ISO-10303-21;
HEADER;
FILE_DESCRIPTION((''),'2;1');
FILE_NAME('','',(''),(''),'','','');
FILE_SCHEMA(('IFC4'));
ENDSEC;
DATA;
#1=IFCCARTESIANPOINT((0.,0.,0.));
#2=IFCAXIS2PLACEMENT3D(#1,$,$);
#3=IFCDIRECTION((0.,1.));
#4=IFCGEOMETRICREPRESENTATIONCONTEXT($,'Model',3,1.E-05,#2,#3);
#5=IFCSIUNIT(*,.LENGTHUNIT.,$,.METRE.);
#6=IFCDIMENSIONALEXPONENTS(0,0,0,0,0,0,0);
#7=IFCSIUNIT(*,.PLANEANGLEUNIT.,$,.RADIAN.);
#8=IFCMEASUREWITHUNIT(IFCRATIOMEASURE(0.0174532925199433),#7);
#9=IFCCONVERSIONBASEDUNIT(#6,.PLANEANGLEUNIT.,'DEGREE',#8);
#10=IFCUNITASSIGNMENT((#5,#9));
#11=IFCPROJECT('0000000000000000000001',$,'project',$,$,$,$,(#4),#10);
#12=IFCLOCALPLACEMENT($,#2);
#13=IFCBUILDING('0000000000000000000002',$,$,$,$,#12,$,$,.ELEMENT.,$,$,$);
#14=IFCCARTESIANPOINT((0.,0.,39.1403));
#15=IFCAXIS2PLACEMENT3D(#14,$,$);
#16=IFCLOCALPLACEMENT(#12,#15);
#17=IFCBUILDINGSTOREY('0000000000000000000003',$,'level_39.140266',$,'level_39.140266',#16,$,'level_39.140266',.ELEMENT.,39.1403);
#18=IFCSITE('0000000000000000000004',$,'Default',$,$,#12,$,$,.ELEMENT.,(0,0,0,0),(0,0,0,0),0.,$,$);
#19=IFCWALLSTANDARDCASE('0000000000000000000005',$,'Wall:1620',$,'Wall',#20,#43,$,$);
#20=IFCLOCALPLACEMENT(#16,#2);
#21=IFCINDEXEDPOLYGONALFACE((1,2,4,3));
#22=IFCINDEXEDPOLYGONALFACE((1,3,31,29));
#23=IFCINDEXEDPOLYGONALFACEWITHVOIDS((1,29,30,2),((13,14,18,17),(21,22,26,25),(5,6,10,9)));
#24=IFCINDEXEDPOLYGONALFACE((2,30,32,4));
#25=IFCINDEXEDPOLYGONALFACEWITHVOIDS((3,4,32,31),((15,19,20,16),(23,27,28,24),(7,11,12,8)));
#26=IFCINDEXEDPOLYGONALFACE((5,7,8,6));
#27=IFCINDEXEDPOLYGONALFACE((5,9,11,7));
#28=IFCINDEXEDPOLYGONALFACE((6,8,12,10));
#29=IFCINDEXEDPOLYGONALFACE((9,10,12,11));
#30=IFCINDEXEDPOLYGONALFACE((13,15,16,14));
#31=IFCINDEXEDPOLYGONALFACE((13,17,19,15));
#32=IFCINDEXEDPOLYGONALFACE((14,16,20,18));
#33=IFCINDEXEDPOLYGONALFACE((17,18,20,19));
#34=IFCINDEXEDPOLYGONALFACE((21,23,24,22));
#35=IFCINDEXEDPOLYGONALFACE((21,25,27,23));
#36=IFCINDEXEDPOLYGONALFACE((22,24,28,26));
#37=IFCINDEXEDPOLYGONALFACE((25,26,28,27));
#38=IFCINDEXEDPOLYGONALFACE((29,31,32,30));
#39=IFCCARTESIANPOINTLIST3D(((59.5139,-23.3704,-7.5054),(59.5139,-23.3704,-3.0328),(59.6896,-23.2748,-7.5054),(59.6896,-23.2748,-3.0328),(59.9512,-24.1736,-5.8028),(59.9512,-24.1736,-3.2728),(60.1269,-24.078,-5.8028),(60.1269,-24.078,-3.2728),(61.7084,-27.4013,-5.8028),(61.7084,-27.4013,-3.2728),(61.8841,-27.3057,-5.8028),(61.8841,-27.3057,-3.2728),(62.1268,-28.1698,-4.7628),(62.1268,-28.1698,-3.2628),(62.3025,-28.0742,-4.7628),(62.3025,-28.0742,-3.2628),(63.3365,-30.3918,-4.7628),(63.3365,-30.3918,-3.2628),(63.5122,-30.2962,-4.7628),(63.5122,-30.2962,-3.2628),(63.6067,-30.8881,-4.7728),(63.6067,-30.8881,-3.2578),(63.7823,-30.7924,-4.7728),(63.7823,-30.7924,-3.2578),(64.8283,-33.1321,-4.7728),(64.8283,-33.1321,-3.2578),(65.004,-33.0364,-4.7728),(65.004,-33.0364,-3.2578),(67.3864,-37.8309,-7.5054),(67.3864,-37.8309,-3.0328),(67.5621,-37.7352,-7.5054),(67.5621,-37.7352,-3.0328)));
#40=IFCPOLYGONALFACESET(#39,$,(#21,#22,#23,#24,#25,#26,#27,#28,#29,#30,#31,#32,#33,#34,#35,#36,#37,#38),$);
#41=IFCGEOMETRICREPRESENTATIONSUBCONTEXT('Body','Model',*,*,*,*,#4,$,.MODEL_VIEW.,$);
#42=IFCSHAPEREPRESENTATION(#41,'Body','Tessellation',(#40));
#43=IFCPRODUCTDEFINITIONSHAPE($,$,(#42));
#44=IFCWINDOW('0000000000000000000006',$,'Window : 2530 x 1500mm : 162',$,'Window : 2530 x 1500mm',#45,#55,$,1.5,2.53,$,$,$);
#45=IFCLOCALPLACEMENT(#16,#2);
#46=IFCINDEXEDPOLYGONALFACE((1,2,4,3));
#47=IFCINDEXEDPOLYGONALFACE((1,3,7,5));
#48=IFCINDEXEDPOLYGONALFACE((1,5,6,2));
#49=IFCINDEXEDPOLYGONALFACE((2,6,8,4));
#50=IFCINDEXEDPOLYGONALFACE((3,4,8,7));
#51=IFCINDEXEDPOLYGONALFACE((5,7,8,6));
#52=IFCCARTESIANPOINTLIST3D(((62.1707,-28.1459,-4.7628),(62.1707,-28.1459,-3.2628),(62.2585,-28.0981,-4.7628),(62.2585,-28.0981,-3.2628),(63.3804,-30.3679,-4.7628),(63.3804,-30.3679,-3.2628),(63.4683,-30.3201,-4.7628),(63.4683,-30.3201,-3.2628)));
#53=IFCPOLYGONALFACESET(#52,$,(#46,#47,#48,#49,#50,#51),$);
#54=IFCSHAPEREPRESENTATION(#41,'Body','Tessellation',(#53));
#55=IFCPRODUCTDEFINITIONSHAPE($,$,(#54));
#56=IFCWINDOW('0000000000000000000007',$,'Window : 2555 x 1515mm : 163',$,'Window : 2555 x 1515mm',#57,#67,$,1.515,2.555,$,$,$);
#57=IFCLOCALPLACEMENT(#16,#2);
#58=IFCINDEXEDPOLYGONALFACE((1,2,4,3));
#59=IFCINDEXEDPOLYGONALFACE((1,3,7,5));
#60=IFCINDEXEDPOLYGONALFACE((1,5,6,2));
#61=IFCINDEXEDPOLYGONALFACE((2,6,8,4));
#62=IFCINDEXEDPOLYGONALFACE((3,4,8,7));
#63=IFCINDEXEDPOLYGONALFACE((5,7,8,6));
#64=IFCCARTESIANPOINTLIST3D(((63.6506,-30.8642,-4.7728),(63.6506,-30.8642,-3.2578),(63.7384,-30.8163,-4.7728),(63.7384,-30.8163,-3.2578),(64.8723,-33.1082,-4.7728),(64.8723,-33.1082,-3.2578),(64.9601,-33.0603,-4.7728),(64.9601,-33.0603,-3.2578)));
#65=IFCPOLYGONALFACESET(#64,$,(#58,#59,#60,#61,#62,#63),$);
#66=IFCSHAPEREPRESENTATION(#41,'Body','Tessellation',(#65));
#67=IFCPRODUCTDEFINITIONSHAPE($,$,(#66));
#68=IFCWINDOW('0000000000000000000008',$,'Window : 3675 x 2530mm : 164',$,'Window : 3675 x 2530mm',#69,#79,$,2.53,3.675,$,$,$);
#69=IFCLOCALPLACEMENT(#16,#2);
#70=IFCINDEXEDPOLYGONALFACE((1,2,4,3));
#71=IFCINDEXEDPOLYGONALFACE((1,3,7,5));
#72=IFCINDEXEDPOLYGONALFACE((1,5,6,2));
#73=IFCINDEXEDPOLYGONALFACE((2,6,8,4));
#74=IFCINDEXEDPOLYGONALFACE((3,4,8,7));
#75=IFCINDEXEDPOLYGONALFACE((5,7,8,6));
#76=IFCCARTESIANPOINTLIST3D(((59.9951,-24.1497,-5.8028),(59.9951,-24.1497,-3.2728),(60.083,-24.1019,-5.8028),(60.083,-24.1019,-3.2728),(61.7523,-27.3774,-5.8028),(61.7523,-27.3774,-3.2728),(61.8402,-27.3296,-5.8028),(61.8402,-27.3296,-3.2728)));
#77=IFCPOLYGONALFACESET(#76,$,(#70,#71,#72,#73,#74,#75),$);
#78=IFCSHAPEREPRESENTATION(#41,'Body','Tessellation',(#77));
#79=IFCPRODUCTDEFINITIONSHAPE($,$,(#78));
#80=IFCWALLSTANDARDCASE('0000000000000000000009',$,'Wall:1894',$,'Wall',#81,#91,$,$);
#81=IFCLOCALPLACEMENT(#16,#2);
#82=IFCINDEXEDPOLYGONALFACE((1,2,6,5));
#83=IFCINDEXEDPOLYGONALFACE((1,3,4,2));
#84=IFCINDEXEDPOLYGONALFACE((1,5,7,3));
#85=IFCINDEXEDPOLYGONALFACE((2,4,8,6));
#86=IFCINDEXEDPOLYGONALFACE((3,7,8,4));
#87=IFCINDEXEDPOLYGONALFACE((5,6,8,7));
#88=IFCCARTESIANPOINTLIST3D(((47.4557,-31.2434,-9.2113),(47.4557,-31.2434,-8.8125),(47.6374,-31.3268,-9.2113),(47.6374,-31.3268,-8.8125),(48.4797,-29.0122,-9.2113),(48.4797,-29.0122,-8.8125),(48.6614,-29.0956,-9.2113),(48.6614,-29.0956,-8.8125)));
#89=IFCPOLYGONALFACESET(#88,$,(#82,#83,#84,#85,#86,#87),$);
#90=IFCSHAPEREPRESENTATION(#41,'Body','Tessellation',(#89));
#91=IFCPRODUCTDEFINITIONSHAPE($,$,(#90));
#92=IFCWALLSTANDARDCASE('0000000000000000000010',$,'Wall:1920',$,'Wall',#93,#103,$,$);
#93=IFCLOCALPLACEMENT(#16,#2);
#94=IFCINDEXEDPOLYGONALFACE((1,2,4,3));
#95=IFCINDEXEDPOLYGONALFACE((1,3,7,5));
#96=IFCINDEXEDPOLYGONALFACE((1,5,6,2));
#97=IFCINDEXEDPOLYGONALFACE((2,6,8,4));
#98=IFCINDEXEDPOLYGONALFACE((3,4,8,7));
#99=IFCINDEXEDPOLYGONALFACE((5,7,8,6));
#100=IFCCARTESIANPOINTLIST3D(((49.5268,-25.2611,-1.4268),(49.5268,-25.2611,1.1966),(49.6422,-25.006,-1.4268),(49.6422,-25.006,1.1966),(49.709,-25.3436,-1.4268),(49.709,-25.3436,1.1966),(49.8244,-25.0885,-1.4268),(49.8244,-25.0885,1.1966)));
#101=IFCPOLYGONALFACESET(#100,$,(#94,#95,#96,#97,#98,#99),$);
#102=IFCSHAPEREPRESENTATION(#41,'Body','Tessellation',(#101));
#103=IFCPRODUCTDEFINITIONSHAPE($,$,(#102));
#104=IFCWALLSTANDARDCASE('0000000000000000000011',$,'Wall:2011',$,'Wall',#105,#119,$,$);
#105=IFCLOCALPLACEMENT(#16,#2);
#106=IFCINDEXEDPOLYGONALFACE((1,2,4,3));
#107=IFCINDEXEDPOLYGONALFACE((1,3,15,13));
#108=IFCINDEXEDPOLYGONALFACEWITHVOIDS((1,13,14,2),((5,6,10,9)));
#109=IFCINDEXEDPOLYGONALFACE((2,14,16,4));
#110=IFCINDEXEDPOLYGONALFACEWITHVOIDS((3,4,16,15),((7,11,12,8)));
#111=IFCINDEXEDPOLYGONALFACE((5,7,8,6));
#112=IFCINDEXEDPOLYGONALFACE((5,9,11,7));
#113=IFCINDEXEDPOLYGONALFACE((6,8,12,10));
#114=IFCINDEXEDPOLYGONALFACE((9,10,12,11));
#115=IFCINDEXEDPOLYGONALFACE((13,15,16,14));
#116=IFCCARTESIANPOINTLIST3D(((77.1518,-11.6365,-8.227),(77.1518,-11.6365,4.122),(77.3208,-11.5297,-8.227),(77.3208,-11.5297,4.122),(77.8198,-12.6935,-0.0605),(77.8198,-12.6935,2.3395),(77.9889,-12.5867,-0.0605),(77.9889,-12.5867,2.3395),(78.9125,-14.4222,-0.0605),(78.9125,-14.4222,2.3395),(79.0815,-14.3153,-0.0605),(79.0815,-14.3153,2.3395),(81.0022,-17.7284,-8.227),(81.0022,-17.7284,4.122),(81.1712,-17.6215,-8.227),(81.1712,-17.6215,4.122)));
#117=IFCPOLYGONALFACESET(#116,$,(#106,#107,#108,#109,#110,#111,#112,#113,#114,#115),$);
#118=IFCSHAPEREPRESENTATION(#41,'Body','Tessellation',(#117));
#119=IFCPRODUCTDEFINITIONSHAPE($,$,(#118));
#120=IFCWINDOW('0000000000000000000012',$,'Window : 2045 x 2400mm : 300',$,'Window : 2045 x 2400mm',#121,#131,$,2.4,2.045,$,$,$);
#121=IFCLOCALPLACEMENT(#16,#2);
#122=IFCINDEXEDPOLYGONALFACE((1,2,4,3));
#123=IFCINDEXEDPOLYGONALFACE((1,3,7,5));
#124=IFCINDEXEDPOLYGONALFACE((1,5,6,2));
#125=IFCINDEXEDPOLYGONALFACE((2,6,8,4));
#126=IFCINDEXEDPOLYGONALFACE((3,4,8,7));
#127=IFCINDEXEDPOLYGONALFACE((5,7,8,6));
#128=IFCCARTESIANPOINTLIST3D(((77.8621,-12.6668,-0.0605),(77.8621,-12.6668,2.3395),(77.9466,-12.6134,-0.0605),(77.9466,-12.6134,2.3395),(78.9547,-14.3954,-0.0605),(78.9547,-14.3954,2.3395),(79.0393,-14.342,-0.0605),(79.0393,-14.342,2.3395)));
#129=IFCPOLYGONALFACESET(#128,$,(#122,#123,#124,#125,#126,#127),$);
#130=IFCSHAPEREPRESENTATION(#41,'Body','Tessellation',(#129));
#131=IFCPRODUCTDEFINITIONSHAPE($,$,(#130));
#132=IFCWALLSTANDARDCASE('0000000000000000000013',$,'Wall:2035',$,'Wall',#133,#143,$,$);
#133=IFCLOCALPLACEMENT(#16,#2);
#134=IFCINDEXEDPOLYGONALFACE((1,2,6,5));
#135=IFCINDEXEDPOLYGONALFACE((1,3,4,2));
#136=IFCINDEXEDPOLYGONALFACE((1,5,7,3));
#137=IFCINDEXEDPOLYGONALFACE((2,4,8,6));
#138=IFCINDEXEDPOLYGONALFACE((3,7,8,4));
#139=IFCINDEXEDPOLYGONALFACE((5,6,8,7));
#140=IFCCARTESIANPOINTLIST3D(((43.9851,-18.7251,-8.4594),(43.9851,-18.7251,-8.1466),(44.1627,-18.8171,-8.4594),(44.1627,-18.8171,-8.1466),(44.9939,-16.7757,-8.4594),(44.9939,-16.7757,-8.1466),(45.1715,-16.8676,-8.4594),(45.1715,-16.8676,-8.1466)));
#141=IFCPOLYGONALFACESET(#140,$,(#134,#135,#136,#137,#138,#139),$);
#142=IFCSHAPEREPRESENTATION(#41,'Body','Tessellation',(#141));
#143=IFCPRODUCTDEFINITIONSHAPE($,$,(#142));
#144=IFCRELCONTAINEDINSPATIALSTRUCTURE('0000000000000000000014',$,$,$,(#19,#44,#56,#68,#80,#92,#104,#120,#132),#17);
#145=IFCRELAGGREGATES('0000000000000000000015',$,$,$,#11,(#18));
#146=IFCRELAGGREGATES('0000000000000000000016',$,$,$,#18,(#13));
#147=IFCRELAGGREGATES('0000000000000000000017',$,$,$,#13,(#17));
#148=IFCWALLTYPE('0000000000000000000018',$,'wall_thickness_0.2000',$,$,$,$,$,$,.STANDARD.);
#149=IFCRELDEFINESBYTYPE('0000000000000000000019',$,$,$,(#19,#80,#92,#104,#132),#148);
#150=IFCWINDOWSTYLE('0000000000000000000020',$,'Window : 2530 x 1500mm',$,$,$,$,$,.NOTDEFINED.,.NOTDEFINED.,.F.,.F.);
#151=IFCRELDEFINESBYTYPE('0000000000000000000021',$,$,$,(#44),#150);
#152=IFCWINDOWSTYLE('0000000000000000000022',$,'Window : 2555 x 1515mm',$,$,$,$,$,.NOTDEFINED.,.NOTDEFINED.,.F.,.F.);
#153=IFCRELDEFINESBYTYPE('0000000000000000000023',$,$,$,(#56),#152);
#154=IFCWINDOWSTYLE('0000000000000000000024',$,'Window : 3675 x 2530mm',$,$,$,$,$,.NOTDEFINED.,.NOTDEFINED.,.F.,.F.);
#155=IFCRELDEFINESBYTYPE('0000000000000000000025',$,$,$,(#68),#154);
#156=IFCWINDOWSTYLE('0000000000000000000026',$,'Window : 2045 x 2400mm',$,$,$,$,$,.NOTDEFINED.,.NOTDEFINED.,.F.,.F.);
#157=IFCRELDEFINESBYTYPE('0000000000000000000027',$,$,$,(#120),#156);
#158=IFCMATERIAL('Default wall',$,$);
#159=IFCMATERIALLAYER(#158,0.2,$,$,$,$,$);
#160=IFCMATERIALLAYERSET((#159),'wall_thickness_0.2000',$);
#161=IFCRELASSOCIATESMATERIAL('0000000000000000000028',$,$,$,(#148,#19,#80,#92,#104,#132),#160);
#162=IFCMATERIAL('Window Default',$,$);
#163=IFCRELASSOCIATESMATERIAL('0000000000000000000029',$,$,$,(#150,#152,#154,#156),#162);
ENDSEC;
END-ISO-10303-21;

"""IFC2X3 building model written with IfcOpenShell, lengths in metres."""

from ifc_helpers import new_model, entity, si_unit, converted_unit, direction, frame, frame_2d, origin, origin_2d_with_axis, place, context, subcontext, project, spatial, polyline, rectangle, outline, extrude, source, transform, mapped, material, layer, layer_set, layer_usage, type_object, type_shapes, element, fill, save


model = new_model("IFC2X3")

# Units and contexts
model_context = context("Model", 3, precision=1e-05, world=origin(), true_north=direction((0.0, 1.0)))
body_context = subcontext(model_context, "Body", "Model", "MODEL_VIEW")
ifc_project = project(units=[si_unit("LENGTHUNIT", "METRE"), converted_unit("PLANEANGLEUNIT", "DEGREE", entity("IfcRatioMeasure", 0.0174532925199433), si_unit("PLANEANGLEUNIT", "RADIAN"), dimensions=[0, 0, 0, 0, 0, 0, 0])], contexts=[model_context])

# Site, building, storey
placement_1 = place(None, origin())
site = spatial("IfcSite", under=ifc_project, at=placement_1, Name="Default", CompositionType="ELEMENT", RefLatitude=(0, 0, 0, 0), RefLongitude=(0, 0, 0, 0), RefElevation=0.0)
building = spatial("IfcBuilding", under=site, at=placement_1, CompositionType="ELEMENT")
storey_placement = place(placement_1, frame((0.0, 0.0, 39.1403)))
storey = spatial("IfcBuildingStorey", under=building, at=storey_placement, Name="level_39.140266", ObjectType="level_39.140266", LongName="level_39.140266", CompositionType="ELEMENT", Elevation=39.1403)

# Shared definitions
ifc_material_1 = material(Name="Default wall")
ifc_layer = layer(ifc_material_1, 0.2)
ifc_layer_set = layer_set([ifc_layer], Name="wall_thickness_0.2000")
ifc_layer_usage = layer_usage(ifc_layer_set, "AXIS2", "POSITIVE", -0.1)
wall_type = type_object("IfcWallType", Name="wall_thickness_0.2000", PredefinedType="STANDARD", material=ifc_layer_set)

# Shared definitions
ifc_material_2 = material(Name="Window Default")

# Wall, openings, windows
placement_2 = place(placement_1, frame((0.0, 0.0, 31.6349)))
wall_1_placement = place(placement_2, frame((59.6018, -23.3226, 0.0), z_axis=(0.0, 0.0, 1.0), x_axis=(0.478148, -0.878279, 0.0)))
wall_1 = element("IfcWallStandardCase", 1, at=wall_1_placement, inside=storey, type_object=wall_type, material=ifc_layer_usage, Name="Wall:1620", ObjectType="Wall", context=body_context, shape_type="SweptSolid", body=[
    extrude(outline(polyline([(16.4645, -0.1), (16.4645, 0.1), (0.0, 0.1), (0.0, -0.1), (16.4645, -0.1)])), origin(), (0.0, 0.0, 1.0), 4.4726),
])
opening_1_placement = place(wall_1_placement, frame((5.4645, -0.1, 2.7426)))
opening_1 = element("IfcOpeningElement", 2, at=opening_1_placement, cuts=wall_1, ObjectType="Opening", context=body_context, shape_type="SweptSolid", body=[
    extrude(rectangle(XDim=2.53, YDim=1.5, at=frame_2d((0.75, 1.265), x_axis=(0.0, 1.0))), frame((0.0, 0.0, 0.0), z_axis=(0.0, 1.0, 0.0), x_axis=(0.0, 0.0, 1.0)), (0.0, 0.0, 1.0), 0.2),
])
opening_2_placement = place(wall_1_placement, frame((8.5595, -0.1, 2.7326)))
opening_2 = element("IfcOpeningElement", 3, at=opening_2_placement, cuts=wall_1, ObjectType="Opening", context=body_context, shape_type="SweptSolid", body=[
    extrude(rectangle(XDim=2.555, YDim=1.515, at=frame_2d((0.7575, 1.2775), x_axis=(0.0, 1.0))), frame((0.0, 0.0, 0.0), z_axis=(0.0, 1.0, 0.0), x_axis=(0.0, 0.0, 1.0)), (0.0, 0.0, 1.0), 0.2),
])
opening_3_placement = place(wall_1_placement, frame((0.9145, -0.1, 1.7026)))
opening_3 = element("IfcOpeningElement", 4, at=opening_3_placement, cuts=wall_1, ObjectType="Opening", context=body_context, shape_type="SweptSolid", body=[
    extrude(rectangle(XDim=3.675, YDim=2.53, at=frame_2d((1.265, 1.8375), x_axis=(0.0, 1.0))), frame((0.0, 0.0, 0.0), z_axis=(0.0, 1.0, 0.0), x_axis=(0.0, 0.0, 1.0)), (0.0, 0.0, 1.0), 0.2),
])
window_style_1 = type_object("IfcWindowStyle", Name="Window : 2530 x 1500mm", ConstructionType="NOTDEFINED", OperationType="NOTDEFINED", ParameterTakesPrecedence=False, Sizeable=False, material=ifc_material_2)
shared_shape_1 = source(origin(), body_context, "Body", "SweptSolid", [
    extrude(rectangle(XDim=0.1, YDim=2.53, at=origin_2d_with_axis()), frame((1.265, 0.1, 0.0), z_axis=(0.0, 0.0, 1.0), x_axis=(0.0, 1.0, 0.0)), (0.0, 0.0, 1.0), 1.5),
])
type_shapes(window_style_1, [shared_shape_1])
window_1_placement = place(opening_1_placement, origin())
window_1 = element("IfcWindow", 5, at=window_1_placement, inside=storey, type_object=window_style_1, Name="Window : 2530 x 1500mm : 162", ObjectType="Window : 2530 x 1500mm", OverallHeight=1.5, OverallWidth=2.53, context=body_context, shape_type="MappedRepresentation", body=[
    mapped(shared_shape_1, transform((0.0, 0.0, 0.0), scale=1.0)),
])
fill(opening_1, window_1)
window_style_2 = type_object("IfcWindowStyle", Name="Window : 2555 x 1515mm", ConstructionType="NOTDEFINED", OperationType="NOTDEFINED", ParameterTakesPrecedence=False, Sizeable=False, material=ifc_material_2)
shared_shape_2 = source(origin(), body_context, "Body", "SweptSolid", [
    extrude(rectangle(XDim=0.1, YDim=2.555, at=origin_2d_with_axis()), frame((1.2775, 0.1, 0.0), z_axis=(0.0, 0.0, 1.0), x_axis=(0.0, 1.0, 0.0)), (0.0, 0.0, 1.0), 1.515),
])
type_shapes(window_style_2, [shared_shape_2])
window_2_placement = place(opening_2_placement, origin())
window_2 = element("IfcWindow", 6, at=window_2_placement, inside=storey, type_object=window_style_2, Name="Window : 2555 x 1515mm : 163", ObjectType="Window : 2555 x 1515mm", OverallHeight=1.515, OverallWidth=2.555, context=body_context, shape_type="MappedRepresentation", body=[
    mapped(shared_shape_2, transform((0.0, 0.0, 0.0), scale=1.0)),
])
fill(opening_2, window_2)
window_style_3 = type_object("IfcWindowStyle", Name="Window : 3675 x 2530mm", ConstructionType="NOTDEFINED", OperationType="NOTDEFINED", ParameterTakesPrecedence=False, Sizeable=False, material=ifc_material_2)
shared_shape_3 = source(origin(), body_context, "Body", "SweptSolid", [
    extrude(rectangle(XDim=0.1, YDim=3.675, at=origin_2d_with_axis()), frame((1.8375, 0.1, 0.0), z_axis=(0.0, 0.0, 1.0), x_axis=(0.0, 1.0, 0.0)), (0.0, 0.0, 1.0), 2.53),
])
type_shapes(window_style_3, [shared_shape_3])
window_3_placement = place(opening_3_placement, origin())
window_3 = element("IfcWindow", 7, at=window_3_placement, inside=storey, type_object=window_style_3, Name="Window : 3675 x 2530mm : 164", ObjectType="Window : 3675 x 2530mm", OverallHeight=2.53, OverallWidth=3.675, context=body_context, shape_type="MappedRepresentation", body=[
    mapped(shared_shape_3, transform((0.0, 0.0, 0.0), scale=1.0)),
])
fill(opening_3, window_3)

# Walls
placement_3 = place(placement_1, frame((0.0, 0.0, 29.929)))
wall_2_placement = place(placement_3, frame((47.5465, -31.2851, 0.0), z_axis=(0.0, 0.0, 1.0), x_axis=(0.41711, 0.908856, 0.0)))
element("IfcWallStandardCase", 8, at=wall_2_placement, inside=storey, type_object=wall_type, material=ifc_layer_usage, Name="Wall:1894", ObjectType="Wall", context=body_context, shape_type="SweptSolid", body=[
    extrude(outline(polyline([(2.455, -0.1), (2.455, 0.1), (0.0, 0.1), (0.0, -0.1), (2.455, -0.1)])), origin(), (0.0, 0.0, 1.0), 0.3988),
])
placement_4 = place(placement_1, frame((0.0, 0.0, 37.7135)))
wall_3_placement = place(placement_4, frame((49.6179, -25.3024, 0.0), z_axis=(0.0, 0.0, 1.0), x_axis=(0.412343, 0.911029, 0.0)))
element("IfcWallStandardCase", 9, at=wall_3_placement, inside=storey, type_object=wall_type, material=ifc_layer_usage, Name="Wall:1920", ObjectType="Wall", context=body_context, shape_type="SweptSolid", body=[
    extrude(outline(polyline([(0.28, -0.1), (0.28, 0.1), (0.0, 0.1), (0.0, -0.1), (0.28, -0.1)])), origin(), (0.0, 0.0, 1.0), 2.6234),
])

# Wall, opening, window
placement_5 = place(placement_1, frame((0.0, 0.0, 30.9133)))
wall_4_placement = place(placement_5, frame((81.0867, -17.6749, 0.0), z_axis=(0.0, 0.0, 1.0), x_axis=(-0.534286, 0.845304, 0.0)))
wall_4 = element("IfcWallStandardCase", 10, at=wall_4_placement, inside=storey, type_object=wall_type, material=ifc_layer_usage, Name="Wall:2011", ObjectType="Wall", context=body_context, shape_type="SweptSolid", body=[
    extrude(outline(polyline([(7.2067, -0.1), (7.2067, 0.1), (0.0, 0.1), (0.0, -0.1), (7.2067, -0.1)])), origin(), (0.0, 0.0, 1.0), 12.349),
])
opening_4_placement = place(wall_4_placement, frame((3.9113, -0.1, 8.1664)))
opening_4 = element("IfcOpeningElement", 11, at=opening_4_placement, cuts=wall_4, ObjectType="Opening", context=body_context, shape_type="SweptSolid", body=[
    extrude(rectangle(XDim=2.045, YDim=2.4, at=frame_2d((1.2, 1.0225), x_axis=(0.0, 1.0))), frame((0.0, 0.0, 0.0), z_axis=(0.0, 1.0, 0.0), x_axis=(0.0, 0.0, 1.0)), (0.0, 0.0, 1.0), 0.2),
])
window_style_4 = type_object("IfcWindowStyle", Name="Window : 2045 x 2400mm", ConstructionType="NOTDEFINED", OperationType="NOTDEFINED", ParameterTakesPrecedence=False, Sizeable=False, material=ifc_material_2)
shared_shape_4 = source(origin(), body_context, "Body", "SweptSolid", [
    extrude(rectangle(XDim=0.1, YDim=2.045, at=origin_2d_with_axis()), frame((1.0225, 0.1, 0.0), z_axis=(0.0, 0.0, 1.0), x_axis=(0.0, 1.0, 0.0)), (0.0, 0.0, 1.0), 2.4),
])
type_shapes(window_style_4, [shared_shape_4])
window_4_placement = place(opening_4_placement, origin())
window_4 = element("IfcWindow", 12, at=window_4_placement, inside=storey, type_object=window_style_4, Name="Window : 2045 x 2400mm : 300", ObjectType="Window : 2045 x 2400mm", OverallHeight=2.4, OverallWidth=2.045, context=body_context, shape_type="MappedRepresentation", body=[
    mapped(shared_shape_4, transform((0.0, 0.0, 0.0), scale=1.0)),
])
fill(opening_4, window_4)

# Wall
placement_6 = place(placement_1, frame((0.0, 0.0, 30.6809)))
wall_5_placement = place(placement_6, frame((44.0739, -18.7711, 0.0), z_axis=(0.0, 0.0, 1.0), x_axis=(0.459599, 0.888126, 0.0)))
element("IfcWallStandardCase", 13, at=wall_5_placement, inside=storey, type_object=wall_type, material=ifc_layer_usage, Name="Wall:2035", ObjectType="Wall", context=body_context, shape_type="SweptSolid", body=[
    extrude(outline(polyline([(2.195, -0.1), (2.195, 0.1), (0.0, 0.1), (0.0, -0.1), (2.195, -0.1)])), origin(), (0.0, 0.0, 1.0), 0.3128),
])

save(model, "model.ifc")
